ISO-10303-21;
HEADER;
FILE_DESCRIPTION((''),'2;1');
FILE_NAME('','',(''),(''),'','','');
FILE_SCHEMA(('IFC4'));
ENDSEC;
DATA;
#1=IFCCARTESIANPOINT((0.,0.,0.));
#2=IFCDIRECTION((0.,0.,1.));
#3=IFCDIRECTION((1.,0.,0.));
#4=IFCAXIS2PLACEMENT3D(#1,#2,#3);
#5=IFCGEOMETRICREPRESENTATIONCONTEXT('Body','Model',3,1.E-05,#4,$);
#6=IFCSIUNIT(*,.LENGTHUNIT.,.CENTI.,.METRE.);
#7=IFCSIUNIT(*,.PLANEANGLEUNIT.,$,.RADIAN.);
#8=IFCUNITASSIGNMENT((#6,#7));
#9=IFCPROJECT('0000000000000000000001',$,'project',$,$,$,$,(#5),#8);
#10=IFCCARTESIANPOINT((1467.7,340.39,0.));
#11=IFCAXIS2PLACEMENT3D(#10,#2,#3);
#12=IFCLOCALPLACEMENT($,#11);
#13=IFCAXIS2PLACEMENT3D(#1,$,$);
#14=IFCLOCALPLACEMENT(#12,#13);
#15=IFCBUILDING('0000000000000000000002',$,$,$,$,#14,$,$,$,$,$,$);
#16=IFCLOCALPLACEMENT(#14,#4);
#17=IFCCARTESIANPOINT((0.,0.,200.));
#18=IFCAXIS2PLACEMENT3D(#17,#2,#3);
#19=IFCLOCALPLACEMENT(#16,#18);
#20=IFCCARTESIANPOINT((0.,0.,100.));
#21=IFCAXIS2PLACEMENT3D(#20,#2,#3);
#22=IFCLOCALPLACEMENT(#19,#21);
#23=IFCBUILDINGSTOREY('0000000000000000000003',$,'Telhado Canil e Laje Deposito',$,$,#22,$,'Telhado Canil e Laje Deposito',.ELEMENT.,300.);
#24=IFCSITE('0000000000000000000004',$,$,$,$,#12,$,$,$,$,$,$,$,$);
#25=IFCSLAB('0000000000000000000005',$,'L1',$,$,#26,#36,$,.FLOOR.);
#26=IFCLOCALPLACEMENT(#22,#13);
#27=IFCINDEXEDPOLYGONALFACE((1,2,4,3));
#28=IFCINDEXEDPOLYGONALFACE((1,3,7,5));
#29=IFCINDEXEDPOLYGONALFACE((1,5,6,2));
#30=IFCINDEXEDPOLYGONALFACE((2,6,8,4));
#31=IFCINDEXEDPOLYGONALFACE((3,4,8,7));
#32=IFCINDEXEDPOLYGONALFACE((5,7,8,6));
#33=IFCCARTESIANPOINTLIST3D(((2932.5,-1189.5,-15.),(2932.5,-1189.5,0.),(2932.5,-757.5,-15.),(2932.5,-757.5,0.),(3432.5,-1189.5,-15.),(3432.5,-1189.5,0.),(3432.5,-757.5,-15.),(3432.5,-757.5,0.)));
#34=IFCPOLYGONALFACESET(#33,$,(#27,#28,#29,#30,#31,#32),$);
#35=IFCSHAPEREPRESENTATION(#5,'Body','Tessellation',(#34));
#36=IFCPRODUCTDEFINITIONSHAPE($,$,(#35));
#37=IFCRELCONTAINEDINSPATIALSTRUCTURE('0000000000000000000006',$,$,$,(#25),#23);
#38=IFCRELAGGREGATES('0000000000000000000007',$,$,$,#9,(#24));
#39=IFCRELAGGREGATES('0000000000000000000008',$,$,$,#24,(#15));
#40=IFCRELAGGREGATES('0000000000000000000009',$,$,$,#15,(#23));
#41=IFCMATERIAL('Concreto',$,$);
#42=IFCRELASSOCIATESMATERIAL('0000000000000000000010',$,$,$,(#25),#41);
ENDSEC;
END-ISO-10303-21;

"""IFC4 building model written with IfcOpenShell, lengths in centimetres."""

from ifc_helpers import new_model, si_unit, frame, origin, origin_with_axes, place, context, project, spatial, polyline, outline, extrude, material, element, save


model = new_model("IFC4")

# Units and contexts
model_context = context("Model", 3, precision=1e-05, world=origin_with_axes(), identifier="Body")
ifc_project = project(units=[si_unit("LENGTHUNIT", "METRE", prefix="CENTI"), si_unit("PLANEANGLEUNIT", "RADIAN")], contexts=[model_context])

# Site, building, storey
site_placement = place(None, frame((1467.7, 340.39, 0.0), z_axis=(0.0, 0.0, 1.0), x_axis=(1.0, 0.0, 0.0)))
site = spatial("IfcSite", under=ifc_project, at=site_placement)
building_placement = place(site_placement, origin())
building = spatial("IfcBuilding", under=site, at=building_placement)
placement_1 = place(building_placement, origin_with_axes())
placement_2 = place(placement_1, frame((0.0, 0.0, 200.0), z_axis=(0.0, 0.0, 1.0), x_axis=(1.0, 0.0, 0.0)))
storey_placement = place(placement_2, frame((0.0, 0.0, 100.0), z_axis=(0.0, 0.0, 1.0), x_axis=(1.0, 0.0, 0.0)))
storey = spatial("IfcBuildingStorey", under=building, at=storey_placement, Name="Telhado Canil e Laje Deposito", LongName="Telhado Canil e Laje Deposito", CompositionType="ELEMENT", Elevation=300.0)

# Shared definitions
ifc_material = material(Name="Concreto")

# Slab
slab_placement = place(storey_placement, frame((3182.5, -973.5, 0.0), z_axis=(0.0, 0.0, 1.0), x_axis=(1.0, 0.0, 0.0)))
element("IfcSlab", 1, at=slab_placement, inside=storey, material=ifc_material, Name="L1", PredefinedType="FLOOR", context=model_context, shape_type="SolidModel", body=[
    extrude(outline(polyline([(250.0, 216.0), (-250.0, 216.0), (-250.0, -216.0), (250.0, -216.0), (250.0, 216.0), (250.0, 216.0)])), frame((0.0, 0.0, -15.0), z_axis=(0.0, 0.0, 1.0), x_axis=(1.0, 0.0, 0.0)), (0.0, 0.0, 1.0), 15.0),
])

save(model, "model.ifc")
